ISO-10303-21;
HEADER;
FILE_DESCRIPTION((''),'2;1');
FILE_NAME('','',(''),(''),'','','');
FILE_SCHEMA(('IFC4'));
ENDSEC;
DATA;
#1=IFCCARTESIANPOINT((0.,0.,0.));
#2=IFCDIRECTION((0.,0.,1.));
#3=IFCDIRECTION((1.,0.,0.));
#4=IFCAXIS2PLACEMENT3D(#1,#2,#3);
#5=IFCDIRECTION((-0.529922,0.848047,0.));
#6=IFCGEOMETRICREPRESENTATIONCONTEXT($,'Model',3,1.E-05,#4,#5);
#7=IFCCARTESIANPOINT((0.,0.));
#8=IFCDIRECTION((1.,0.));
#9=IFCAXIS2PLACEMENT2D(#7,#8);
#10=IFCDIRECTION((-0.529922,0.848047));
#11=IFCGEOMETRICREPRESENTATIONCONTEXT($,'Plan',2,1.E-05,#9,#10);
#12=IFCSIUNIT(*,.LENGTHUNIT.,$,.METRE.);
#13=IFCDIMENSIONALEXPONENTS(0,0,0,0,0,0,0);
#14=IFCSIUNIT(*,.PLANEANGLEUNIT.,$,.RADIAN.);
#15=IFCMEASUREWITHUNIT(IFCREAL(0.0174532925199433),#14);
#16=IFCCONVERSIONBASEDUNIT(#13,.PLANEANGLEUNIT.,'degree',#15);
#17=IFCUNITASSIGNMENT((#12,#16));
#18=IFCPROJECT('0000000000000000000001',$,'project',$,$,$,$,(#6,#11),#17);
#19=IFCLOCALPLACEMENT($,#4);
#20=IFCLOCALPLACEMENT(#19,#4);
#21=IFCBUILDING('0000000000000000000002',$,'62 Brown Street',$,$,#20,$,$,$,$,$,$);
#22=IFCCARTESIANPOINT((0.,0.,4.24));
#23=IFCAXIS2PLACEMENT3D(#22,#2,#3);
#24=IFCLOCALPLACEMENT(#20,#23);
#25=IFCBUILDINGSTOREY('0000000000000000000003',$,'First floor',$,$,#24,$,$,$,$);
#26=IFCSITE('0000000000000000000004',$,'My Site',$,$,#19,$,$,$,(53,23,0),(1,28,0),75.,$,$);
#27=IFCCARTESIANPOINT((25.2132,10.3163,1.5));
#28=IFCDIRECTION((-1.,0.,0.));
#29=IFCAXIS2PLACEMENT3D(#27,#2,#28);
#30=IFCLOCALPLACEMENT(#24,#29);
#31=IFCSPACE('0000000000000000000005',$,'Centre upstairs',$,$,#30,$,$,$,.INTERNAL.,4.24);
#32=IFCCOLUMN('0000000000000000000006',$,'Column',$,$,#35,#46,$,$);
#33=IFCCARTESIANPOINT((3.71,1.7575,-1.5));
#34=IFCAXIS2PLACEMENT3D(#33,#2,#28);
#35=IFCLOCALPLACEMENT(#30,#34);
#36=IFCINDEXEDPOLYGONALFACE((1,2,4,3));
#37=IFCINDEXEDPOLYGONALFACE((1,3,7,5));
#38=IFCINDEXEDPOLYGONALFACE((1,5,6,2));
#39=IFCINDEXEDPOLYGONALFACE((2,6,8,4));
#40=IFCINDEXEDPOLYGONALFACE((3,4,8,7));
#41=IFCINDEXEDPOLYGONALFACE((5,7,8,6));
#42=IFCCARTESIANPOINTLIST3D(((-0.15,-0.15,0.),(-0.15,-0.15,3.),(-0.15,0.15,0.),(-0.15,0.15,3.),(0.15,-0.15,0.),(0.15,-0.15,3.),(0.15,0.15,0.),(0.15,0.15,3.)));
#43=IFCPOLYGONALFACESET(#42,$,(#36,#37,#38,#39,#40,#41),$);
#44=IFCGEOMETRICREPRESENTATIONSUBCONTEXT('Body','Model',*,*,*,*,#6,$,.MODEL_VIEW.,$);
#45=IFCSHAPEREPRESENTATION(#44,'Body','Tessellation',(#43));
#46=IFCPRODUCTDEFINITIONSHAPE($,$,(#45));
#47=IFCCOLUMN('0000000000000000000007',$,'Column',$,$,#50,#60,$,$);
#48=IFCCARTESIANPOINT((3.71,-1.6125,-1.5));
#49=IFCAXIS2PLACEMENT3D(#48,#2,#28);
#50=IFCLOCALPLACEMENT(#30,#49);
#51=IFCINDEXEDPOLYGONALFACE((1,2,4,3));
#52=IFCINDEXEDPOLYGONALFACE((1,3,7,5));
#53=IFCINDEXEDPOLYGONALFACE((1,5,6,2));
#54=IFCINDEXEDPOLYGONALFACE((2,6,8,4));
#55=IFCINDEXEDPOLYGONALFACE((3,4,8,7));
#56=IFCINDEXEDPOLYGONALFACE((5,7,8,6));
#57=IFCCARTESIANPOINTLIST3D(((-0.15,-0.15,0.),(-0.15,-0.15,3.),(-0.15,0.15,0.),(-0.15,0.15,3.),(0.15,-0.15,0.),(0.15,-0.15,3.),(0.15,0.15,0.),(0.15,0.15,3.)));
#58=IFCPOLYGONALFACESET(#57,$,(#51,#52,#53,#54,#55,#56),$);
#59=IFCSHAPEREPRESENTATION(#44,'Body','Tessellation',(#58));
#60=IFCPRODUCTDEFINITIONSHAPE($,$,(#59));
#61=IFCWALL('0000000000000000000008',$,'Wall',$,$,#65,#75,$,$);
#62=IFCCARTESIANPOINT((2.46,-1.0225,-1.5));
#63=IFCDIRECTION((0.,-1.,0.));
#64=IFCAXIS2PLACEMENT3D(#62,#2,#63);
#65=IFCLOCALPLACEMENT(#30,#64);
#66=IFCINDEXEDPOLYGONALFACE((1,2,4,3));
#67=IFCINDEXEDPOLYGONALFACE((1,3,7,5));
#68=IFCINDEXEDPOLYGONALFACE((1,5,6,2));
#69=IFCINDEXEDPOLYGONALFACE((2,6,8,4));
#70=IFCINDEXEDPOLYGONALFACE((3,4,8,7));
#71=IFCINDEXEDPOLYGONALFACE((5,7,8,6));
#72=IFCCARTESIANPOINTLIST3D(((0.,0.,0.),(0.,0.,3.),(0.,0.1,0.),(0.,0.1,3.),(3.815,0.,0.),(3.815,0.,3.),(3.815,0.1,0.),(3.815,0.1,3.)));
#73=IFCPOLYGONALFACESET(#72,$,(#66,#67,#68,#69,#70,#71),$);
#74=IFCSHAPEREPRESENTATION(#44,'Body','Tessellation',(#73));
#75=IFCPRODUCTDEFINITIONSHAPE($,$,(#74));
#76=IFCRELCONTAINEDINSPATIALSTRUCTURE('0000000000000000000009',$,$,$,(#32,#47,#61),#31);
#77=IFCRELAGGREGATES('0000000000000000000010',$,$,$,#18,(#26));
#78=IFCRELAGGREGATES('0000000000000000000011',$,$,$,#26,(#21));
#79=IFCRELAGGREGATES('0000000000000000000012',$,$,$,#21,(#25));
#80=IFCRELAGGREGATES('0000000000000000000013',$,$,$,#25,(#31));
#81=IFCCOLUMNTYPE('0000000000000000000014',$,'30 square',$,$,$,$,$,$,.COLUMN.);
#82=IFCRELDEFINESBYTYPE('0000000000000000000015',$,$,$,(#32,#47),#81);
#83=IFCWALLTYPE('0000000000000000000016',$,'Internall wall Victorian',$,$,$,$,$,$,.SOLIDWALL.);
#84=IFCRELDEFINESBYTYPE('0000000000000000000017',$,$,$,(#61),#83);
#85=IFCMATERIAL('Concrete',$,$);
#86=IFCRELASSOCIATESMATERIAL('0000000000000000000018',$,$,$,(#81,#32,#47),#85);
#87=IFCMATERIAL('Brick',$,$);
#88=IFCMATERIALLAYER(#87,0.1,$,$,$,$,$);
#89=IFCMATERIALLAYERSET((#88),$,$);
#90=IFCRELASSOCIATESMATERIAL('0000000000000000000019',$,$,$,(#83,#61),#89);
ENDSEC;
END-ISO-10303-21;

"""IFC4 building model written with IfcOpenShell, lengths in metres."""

from ifc_helpers import new_model, entity, si_unit, converted_unit, direction, frame, origin_with_axes, origin_2d_with_axis, place, context, subcontext, project, spatial, indexed_curve, rectangle, outline, extrude, material, layer, layer_set, layer_usage, material_profile, profile_set, profile_usage, type_object, element, save


model = new_model("IFC4")

# Units and contexts
model_context = context("Model", 3, precision=1e-05, world=origin_with_axes(), true_north=direction((-0.529922, 0.848047, 0.0)))
plan_context = context("Plan", 2, precision=1e-05, world=origin_2d_with_axis(), true_north=direction((-0.529922, 0.848047)))
body_context = subcontext(model_context, "Body", "Model", "MODEL_VIEW")
ifc_project = project(units=[si_unit("LENGTHUNIT", "METRE"), converted_unit("PLANEANGLEUNIT", "degree", entity("IfcReal", 0.0174532925199433), si_unit("PLANEANGLEUNIT", "RADIAN"), dimensions=[0, 0, 0, 0, 0, 0, 0])], contexts=[model_context, plan_context])

# Site, building, storey, space
site_placement = place(None, origin_with_axes())
site = spatial("IfcSite", under=ifc_project, at=site_placement, Name="My Site", RefLatitude=(53, 23, 0), RefLongitude=(1, 28, 0), RefElevation=75.0)
building_placement = place(site_placement, origin_with_axes())
building = spatial("IfcBuilding", under=site, at=building_placement, Name="62 Brown Street")
storey_placement = place(building_placement, frame((0.0, 0.0, 4.24), z_axis=(0.0, 0.0, 1.0), x_axis=(1.0, 0.0, 0.0)))
storey = spatial("IfcBuildingStorey", under=building, at=storey_placement, Name="First floor")
space_1_placement = place(storey_placement, frame((25.2132, 10.3163, 1.5), z_axis=(0.0, 0.0, 1.0), x_axis=(-1.0, 0.0, 0.0)))
space_1 = spatial("IfcSpace", under=storey, at=space_1_placement, Name="Centre upstairs", PredefinedType="INTERNAL", ElevationWithFlooring=4.24)

# Columns
ifc_material_1 = material(Name="Concrete")
ifc_material_profile_1 = material_profile(ifc_material_1, rectangle(XDim=0.3, YDim=0.3))
ifc_profile_set_1 = profile_set([ifc_material_profile_1])
ifc_profile_usage_1 = profile_usage(ifc_profile_set_1, cardinal=5)
column_type = type_object("IfcColumnType", Name="30 square", PredefinedType="COLUMN", material=ifc_profile_set_1)
column_1_placement = place(space_1_placement, frame((3.71, 1.7575, -1.5), z_axis=(0.0, 0.0, 1.0), x_axis=(-1.0, 0.0, 0.0)))
element("IfcColumn", 1, at=column_1_placement, inside=space_1, type_object=column_type, material=ifc_profile_usage_1, Name="Column", context=body_context, shape_type="SweptSolid", body=[
    extrude(rectangle(XDim=0.3, YDim=0.3), origin_with_axes(), (0.0, 0.0, 1.0), 3.0),
])
ifc_profile_usage_2 = profile_usage(ifc_profile_set_1, cardinal=5)
column_2_placement = place(space_1_placement, frame((3.71, -1.6125, -1.5), z_axis=(0.0, 0.0, 1.0), x_axis=(-1.0, 0.0, 0.0)))
element("IfcColumn", 2, at=column_2_placement, inside=space_1, type_object=column_type, material=ifc_profile_usage_2, Name="Column", context=body_context, shape_type="SweptSolid", body=[
    extrude(rectangle(XDim=0.3, YDim=0.3), origin_with_axes(), (0.0, 0.0, 1.0), 3.0),
])

# Wall
ifc_material_2 = material(Name="Brick")
ifc_layer_1 = layer(ifc_material_2, 0.1)
ifc_layer_set_1 = layer_set([ifc_layer_1])
ifc_layer_usage_1 = layer_usage(ifc_layer_set_1, "AXIS2", "POSITIVE", 0.0)
wall_type_1 = type_object("IfcWallType", Name="Internall wall Victorian", PredefinedType="SOLIDWALL", material=ifc_layer_set_1)
wall_1_placement = place(space_1_placement, frame((2.46, -1.0225, -1.5), z_axis=(0.0, 0.0, 1.0), x_axis=(0.0, -1.0, 0.0)))
element("IfcWall", 3, at=wall_1_placement, inside=space_1, type_object=wall_type_1, material=ifc_layer_usage_1, Name="Wall", context=body_context, shape_type="SweptSolid", body=[
    extrude(outline(indexed_curve([(0.0, 0.0), (0.0, 0.1), (3.815, 0.1), (3.815, 0.0), (0.0, 0.0)], self_intersect=False)), origin_with_axes(), (0.0, 0.0, 1.0), 3.0),
])

save(model, "model.ifc")
